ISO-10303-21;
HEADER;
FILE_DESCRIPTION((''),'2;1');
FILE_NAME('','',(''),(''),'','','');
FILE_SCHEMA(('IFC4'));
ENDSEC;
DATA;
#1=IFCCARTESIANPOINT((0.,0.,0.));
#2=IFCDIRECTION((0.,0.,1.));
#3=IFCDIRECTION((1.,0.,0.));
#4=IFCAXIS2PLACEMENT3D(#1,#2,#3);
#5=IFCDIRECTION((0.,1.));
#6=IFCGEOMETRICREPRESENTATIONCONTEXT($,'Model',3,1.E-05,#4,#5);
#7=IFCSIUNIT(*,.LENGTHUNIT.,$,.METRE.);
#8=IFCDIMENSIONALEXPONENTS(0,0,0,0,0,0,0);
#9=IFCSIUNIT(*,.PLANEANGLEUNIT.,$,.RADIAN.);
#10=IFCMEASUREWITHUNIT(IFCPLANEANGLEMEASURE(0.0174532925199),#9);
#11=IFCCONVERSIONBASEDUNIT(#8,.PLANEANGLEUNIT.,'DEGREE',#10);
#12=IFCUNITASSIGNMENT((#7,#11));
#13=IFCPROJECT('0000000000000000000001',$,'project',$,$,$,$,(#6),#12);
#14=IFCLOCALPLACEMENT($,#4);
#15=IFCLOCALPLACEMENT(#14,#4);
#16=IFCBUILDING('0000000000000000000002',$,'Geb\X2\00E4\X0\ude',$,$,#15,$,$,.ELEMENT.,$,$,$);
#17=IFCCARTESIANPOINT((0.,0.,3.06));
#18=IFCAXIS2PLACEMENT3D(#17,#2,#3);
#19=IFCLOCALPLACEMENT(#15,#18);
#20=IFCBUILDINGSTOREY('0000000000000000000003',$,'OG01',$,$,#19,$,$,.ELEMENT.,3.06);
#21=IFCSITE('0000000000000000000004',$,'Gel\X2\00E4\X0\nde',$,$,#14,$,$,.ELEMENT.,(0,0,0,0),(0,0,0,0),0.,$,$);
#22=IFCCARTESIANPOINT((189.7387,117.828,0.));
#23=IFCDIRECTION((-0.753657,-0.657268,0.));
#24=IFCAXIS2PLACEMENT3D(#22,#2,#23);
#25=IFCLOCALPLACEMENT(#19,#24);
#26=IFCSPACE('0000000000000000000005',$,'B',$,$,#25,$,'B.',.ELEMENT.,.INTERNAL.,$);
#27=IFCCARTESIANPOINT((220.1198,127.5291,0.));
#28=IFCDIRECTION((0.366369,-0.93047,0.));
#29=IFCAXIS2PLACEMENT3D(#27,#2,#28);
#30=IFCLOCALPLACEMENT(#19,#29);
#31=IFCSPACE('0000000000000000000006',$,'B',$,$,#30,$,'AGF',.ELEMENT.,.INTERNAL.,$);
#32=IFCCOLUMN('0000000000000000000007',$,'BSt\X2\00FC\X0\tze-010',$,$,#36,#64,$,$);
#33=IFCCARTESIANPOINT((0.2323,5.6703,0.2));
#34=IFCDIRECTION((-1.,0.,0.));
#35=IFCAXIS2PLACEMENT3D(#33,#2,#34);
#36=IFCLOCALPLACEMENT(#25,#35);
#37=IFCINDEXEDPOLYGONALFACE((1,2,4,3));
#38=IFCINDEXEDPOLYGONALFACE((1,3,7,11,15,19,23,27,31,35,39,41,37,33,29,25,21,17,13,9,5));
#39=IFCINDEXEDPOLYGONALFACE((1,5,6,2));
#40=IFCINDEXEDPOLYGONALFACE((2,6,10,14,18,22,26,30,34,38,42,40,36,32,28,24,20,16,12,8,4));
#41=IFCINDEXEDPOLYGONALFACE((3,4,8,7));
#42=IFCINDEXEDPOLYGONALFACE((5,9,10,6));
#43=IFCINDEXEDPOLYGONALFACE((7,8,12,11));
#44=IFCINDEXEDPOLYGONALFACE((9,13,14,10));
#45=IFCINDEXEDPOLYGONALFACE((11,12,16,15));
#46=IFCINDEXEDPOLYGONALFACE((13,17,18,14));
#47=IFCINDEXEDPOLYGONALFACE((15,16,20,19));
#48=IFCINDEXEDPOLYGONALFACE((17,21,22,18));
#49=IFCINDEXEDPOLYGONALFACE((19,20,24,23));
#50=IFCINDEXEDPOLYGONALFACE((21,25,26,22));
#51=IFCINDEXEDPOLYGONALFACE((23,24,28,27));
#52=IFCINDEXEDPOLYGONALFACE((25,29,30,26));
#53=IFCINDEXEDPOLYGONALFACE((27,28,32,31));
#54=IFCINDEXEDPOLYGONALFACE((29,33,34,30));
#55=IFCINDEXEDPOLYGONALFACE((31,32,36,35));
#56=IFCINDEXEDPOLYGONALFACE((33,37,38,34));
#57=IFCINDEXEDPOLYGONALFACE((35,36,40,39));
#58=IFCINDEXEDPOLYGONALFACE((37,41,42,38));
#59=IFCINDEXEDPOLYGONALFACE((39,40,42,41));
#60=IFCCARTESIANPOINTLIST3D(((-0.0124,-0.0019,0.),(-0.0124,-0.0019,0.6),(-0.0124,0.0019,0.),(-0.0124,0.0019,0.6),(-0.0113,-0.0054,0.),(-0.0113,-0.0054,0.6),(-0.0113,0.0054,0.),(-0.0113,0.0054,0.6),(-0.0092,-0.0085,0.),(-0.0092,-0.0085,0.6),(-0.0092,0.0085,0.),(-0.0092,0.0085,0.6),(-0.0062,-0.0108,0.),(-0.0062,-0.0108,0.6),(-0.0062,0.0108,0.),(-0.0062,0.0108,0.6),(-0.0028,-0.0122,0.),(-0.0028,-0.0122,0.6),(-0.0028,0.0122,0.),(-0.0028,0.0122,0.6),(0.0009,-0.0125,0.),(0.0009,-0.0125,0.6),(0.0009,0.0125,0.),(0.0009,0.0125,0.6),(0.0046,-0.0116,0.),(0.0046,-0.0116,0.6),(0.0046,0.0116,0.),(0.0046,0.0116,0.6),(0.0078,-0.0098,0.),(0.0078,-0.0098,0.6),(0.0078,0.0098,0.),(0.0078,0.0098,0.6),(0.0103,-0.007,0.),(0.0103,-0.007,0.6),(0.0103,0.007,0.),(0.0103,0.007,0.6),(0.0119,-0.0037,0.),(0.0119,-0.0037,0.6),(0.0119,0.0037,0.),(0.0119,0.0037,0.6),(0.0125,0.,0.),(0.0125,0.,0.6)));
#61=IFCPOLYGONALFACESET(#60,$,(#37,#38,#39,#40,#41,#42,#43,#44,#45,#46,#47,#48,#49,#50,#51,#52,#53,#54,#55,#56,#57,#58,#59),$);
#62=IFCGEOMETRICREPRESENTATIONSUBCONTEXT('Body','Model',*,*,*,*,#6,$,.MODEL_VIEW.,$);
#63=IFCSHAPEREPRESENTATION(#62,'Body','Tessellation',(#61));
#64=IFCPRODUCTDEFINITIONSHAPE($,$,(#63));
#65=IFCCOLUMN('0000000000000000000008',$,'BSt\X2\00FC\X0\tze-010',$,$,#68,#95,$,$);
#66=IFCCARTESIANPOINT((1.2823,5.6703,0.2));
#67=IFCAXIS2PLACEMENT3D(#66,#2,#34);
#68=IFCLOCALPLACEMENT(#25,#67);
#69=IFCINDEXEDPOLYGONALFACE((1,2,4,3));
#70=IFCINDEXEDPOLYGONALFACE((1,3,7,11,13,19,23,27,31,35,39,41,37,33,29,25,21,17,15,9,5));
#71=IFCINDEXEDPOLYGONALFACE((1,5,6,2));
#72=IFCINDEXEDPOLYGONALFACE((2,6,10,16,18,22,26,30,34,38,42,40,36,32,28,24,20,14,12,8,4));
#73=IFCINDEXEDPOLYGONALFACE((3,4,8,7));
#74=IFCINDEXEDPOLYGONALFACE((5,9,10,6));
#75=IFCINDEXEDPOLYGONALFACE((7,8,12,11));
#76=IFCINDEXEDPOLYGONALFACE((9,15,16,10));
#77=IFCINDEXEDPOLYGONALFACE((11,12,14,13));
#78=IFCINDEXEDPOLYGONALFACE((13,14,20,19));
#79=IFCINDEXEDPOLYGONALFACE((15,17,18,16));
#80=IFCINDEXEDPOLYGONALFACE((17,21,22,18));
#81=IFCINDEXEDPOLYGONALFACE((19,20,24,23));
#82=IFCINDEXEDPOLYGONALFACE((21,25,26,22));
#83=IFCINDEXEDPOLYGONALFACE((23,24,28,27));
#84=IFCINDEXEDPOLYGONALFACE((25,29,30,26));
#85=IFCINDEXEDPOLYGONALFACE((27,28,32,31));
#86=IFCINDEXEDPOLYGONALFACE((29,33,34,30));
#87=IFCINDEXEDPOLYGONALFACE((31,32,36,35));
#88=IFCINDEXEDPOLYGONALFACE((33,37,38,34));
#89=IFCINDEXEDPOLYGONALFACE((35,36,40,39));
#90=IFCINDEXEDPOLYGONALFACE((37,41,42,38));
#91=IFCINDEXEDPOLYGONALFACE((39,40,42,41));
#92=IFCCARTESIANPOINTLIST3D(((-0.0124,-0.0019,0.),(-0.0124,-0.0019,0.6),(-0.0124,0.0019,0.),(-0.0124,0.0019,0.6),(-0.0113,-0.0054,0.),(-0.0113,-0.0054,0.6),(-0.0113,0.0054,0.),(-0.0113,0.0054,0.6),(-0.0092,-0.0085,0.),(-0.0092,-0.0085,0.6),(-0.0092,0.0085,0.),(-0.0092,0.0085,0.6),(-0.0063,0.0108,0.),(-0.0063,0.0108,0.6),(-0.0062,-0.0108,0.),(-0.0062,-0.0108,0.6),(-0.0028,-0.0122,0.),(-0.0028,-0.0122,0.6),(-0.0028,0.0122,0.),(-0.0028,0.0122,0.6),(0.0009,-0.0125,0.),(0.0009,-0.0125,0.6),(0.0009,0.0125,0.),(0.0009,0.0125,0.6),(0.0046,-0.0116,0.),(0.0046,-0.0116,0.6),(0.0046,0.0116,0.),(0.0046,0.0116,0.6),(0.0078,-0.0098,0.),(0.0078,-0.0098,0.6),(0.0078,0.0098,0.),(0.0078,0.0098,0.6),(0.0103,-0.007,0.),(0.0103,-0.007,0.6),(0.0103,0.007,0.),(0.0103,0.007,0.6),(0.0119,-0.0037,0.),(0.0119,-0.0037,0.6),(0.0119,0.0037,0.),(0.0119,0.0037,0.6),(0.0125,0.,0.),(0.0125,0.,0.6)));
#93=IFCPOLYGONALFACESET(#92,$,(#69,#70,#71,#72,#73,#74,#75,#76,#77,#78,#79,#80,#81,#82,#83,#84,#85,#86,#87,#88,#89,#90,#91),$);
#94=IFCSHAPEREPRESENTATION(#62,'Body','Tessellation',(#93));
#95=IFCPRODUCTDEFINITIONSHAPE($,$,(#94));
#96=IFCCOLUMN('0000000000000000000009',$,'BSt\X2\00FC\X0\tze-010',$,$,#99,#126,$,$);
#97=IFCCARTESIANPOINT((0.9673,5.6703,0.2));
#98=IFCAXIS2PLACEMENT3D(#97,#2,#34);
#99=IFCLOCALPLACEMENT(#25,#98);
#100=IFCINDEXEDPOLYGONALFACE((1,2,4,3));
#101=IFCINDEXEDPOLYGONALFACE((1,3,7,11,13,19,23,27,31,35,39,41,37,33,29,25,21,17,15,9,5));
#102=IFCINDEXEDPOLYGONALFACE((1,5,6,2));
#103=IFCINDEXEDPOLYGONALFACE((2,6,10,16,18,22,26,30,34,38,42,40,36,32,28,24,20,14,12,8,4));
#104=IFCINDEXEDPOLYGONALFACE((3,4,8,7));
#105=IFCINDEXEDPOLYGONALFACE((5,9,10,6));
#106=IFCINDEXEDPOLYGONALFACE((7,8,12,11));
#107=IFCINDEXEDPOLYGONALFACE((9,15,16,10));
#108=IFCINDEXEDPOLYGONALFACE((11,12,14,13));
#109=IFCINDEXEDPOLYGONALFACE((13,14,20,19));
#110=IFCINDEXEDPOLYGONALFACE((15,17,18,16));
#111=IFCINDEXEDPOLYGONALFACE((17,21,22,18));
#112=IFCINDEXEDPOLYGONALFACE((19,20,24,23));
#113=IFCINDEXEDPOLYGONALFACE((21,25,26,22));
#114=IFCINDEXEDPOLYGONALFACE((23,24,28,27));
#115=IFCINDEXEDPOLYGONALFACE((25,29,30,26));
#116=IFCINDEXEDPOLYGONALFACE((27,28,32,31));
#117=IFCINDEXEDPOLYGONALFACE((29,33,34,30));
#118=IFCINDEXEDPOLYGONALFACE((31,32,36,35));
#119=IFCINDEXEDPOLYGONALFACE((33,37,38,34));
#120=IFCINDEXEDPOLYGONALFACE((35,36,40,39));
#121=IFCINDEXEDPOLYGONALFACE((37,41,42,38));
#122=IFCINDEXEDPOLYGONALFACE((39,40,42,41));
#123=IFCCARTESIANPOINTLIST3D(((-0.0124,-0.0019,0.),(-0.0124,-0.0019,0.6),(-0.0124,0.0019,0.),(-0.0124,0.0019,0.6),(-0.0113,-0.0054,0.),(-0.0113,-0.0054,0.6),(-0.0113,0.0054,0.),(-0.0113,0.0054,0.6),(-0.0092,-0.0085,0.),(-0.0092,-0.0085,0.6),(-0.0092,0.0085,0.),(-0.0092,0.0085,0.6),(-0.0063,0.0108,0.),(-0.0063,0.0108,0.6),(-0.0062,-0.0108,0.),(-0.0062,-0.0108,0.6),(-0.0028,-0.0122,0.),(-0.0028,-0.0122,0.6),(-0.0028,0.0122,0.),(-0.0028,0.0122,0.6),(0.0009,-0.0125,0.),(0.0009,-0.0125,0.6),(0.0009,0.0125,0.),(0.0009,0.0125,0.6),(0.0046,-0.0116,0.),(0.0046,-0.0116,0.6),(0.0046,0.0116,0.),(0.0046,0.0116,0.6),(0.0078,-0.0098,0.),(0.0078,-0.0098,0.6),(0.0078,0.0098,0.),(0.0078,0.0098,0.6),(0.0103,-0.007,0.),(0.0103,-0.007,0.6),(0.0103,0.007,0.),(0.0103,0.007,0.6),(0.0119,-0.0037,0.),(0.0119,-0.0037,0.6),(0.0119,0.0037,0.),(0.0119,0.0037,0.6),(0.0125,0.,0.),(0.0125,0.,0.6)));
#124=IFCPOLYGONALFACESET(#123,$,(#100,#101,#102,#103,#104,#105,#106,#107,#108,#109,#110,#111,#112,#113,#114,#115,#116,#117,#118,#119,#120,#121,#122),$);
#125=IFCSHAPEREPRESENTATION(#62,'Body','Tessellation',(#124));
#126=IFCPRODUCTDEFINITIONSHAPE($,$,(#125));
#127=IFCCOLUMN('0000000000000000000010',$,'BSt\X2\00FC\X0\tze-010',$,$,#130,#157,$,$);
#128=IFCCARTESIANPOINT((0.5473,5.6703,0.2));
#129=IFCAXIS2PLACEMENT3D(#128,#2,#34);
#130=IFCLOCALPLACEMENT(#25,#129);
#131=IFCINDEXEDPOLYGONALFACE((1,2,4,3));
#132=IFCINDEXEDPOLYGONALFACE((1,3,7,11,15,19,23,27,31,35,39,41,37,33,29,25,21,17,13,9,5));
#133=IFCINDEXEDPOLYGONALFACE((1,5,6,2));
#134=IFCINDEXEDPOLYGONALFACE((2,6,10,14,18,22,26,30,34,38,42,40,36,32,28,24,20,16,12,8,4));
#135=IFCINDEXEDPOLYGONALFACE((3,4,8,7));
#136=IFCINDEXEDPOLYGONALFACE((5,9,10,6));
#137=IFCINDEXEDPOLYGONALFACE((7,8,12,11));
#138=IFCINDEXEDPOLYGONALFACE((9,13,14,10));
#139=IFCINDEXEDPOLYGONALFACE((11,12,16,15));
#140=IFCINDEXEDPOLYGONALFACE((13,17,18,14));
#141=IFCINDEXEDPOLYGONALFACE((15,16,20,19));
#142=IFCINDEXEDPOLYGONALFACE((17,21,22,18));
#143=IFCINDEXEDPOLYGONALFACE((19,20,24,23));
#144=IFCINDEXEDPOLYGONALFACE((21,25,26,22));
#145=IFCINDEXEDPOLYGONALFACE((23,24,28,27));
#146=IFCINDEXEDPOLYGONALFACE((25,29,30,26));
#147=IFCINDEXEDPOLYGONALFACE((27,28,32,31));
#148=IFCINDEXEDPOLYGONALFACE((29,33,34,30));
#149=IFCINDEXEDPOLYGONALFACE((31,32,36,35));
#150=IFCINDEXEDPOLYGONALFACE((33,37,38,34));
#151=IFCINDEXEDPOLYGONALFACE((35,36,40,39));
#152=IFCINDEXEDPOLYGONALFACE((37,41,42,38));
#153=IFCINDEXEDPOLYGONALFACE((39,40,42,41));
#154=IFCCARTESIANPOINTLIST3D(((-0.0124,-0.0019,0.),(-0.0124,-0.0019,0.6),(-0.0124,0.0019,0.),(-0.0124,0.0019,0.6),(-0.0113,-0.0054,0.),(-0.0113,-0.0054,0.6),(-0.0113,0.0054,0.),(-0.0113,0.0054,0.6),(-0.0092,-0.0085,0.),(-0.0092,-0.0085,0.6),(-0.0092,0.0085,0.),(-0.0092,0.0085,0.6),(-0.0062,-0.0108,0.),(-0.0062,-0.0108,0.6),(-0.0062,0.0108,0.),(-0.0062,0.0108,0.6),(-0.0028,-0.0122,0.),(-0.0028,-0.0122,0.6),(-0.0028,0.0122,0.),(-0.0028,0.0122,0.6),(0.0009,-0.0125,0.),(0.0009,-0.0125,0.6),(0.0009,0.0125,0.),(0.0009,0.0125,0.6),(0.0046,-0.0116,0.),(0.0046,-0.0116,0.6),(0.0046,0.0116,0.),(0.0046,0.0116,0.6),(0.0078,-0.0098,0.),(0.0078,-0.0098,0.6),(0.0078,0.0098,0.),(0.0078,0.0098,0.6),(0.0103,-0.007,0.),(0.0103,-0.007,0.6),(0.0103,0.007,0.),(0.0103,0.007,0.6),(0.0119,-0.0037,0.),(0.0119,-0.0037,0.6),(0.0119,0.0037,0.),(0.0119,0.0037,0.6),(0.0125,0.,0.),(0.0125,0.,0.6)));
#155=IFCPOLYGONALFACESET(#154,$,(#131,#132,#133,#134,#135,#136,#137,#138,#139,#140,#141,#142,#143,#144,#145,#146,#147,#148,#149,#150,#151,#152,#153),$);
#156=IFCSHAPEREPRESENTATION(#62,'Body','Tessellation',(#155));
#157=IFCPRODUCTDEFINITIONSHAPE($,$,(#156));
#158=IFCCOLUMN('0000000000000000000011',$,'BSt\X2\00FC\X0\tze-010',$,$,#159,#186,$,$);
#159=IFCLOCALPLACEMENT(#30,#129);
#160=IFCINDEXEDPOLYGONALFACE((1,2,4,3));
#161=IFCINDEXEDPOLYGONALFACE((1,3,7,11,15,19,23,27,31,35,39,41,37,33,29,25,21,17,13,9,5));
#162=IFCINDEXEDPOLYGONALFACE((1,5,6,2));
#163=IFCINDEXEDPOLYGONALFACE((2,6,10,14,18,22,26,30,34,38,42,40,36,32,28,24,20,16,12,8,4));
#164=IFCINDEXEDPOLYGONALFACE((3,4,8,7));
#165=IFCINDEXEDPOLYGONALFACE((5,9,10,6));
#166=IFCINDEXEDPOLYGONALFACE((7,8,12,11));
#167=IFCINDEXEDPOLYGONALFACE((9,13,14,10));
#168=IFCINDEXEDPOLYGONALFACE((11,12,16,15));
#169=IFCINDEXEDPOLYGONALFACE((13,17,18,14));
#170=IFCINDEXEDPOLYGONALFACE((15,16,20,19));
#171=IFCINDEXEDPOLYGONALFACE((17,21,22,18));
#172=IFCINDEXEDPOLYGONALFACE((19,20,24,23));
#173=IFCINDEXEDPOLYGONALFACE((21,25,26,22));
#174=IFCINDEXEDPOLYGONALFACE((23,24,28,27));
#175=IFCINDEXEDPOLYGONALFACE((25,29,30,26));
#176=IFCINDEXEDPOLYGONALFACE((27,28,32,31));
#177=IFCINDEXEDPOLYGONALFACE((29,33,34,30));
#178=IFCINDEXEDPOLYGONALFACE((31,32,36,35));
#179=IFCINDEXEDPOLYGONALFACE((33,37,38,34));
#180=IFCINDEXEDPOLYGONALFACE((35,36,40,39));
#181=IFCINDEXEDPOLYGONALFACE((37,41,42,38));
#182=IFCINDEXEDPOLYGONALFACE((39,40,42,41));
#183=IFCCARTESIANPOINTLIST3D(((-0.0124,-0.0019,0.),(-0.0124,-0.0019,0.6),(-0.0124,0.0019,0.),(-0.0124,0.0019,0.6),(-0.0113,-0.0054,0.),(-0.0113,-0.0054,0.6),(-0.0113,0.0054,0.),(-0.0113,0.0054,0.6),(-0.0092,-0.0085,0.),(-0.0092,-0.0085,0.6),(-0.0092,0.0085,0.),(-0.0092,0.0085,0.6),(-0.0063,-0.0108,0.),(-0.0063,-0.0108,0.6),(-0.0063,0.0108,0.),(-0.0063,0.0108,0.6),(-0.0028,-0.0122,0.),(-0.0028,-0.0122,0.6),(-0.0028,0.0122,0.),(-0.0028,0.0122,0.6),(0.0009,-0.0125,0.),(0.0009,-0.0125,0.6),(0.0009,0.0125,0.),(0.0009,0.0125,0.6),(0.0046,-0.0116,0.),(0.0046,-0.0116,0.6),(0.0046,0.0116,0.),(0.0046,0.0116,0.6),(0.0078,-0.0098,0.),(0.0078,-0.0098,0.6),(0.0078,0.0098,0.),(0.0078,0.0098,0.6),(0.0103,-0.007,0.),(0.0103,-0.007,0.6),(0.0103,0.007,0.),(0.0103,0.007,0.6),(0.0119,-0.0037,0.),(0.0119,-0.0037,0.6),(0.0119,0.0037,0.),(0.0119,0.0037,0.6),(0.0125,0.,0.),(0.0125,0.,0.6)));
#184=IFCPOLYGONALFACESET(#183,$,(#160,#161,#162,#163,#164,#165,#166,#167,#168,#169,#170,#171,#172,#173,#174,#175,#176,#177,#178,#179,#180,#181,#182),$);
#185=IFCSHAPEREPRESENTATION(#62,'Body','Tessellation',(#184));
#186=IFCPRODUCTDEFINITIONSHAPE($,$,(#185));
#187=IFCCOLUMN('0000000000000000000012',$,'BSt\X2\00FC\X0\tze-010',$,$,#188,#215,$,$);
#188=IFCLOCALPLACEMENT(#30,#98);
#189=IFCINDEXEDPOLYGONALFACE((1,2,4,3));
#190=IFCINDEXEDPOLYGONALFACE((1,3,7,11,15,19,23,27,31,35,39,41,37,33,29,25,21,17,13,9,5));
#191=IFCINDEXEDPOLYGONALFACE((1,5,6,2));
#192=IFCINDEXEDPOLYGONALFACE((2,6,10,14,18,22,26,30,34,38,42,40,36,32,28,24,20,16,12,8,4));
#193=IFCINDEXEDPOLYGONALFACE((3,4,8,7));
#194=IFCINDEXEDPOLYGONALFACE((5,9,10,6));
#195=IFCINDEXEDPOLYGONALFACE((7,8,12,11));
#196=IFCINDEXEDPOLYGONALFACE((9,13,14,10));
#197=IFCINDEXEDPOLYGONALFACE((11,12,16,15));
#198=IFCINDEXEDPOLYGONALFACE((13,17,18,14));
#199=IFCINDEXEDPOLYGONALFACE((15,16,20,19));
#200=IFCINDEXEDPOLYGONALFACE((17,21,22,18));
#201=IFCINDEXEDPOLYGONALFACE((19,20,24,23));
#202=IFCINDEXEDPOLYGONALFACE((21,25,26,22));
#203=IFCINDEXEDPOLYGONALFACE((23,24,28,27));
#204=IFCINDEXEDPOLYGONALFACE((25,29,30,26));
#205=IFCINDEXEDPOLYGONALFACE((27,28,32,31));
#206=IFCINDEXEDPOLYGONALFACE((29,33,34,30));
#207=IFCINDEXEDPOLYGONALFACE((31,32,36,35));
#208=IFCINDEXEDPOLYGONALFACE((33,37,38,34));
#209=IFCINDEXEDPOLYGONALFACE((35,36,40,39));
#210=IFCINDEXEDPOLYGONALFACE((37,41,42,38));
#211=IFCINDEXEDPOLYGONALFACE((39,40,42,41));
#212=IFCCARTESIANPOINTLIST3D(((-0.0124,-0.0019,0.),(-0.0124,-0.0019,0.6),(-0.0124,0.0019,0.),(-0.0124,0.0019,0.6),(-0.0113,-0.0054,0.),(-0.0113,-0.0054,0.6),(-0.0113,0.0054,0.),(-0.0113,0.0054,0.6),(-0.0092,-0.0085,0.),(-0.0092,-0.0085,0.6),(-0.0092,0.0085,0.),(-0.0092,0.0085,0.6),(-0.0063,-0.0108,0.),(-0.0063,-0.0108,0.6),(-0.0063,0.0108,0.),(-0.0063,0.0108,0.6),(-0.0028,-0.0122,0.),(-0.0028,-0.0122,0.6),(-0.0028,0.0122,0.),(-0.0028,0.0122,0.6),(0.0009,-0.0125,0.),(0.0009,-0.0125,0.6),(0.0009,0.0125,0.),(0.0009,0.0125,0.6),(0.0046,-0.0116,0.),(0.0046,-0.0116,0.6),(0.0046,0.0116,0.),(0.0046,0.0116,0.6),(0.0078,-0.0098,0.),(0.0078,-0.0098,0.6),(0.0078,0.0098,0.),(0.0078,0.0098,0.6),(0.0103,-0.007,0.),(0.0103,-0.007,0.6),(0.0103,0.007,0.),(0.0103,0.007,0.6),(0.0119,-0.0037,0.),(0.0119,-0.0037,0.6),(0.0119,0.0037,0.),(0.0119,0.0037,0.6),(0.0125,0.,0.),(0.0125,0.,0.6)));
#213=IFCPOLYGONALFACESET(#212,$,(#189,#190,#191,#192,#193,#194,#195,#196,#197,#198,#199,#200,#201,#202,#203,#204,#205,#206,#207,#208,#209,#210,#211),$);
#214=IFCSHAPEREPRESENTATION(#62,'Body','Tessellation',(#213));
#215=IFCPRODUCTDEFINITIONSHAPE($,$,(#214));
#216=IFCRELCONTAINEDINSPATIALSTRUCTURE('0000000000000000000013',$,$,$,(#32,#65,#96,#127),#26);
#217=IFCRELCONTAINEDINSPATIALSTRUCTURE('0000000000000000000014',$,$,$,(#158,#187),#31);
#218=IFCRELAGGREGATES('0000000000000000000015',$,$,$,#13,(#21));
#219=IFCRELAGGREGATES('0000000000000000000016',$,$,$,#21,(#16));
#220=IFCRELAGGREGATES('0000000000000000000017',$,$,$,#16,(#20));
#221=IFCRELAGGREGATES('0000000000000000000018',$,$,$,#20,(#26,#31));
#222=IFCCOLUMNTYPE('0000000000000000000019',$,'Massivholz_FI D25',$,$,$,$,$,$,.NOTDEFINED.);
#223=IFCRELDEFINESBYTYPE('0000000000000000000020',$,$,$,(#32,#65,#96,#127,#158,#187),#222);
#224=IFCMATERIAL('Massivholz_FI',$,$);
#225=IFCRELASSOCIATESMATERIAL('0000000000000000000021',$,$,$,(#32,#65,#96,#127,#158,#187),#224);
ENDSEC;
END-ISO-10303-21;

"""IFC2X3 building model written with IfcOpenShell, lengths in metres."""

from ifc_helpers import new_model, entity, si_unit, converted_unit, direction, frame, origin_with_axes, origin_2d_with_axis, place, context, subcontext, project, spatial, circle, extrude, material, type_object, element, save


model = new_model("IFC2X3")

# Units and contexts
model_context = context("Model", 3, precision=1e-05, world=origin_with_axes(), true_north=direction((0.0, 1.0)))
body_context = subcontext(model_context, "Body", "Model", "MODEL_VIEW")
ifc_project = project(units=[si_unit("LENGTHUNIT", "METRE"), converted_unit("PLANEANGLEUNIT", "DEGREE", entity("IfcPlaneAngleMeasure", 0.0174532925199), si_unit("PLANEANGLEUNIT", "RADIAN"), dimensions=[0, 0, 0, 0, 0, 0, 0])], contexts=[model_context])

# Site, building, storey, space
site_placement = place(None, origin_with_axes())
site = spatial("IfcSite", under=ifc_project, at=site_placement, Name="Gelände", CompositionType="ELEMENT", RefLatitude=(0, 0, 0, 0), RefLongitude=(0, 0, 0, 0), RefElevation=0.0)
building_placement = place(site_placement, origin_with_axes())
building = spatial("IfcBuilding", under=site, at=building_placement, Name="Gebäude", CompositionType="ELEMENT")
storey_placement = place(building_placement, frame((0.0, 0.0, 3.06), z_axis=(0.0, 0.0, 1.0), x_axis=(1.0, 0.0, 0.0)))
storey = spatial("IfcBuildingStorey", under=building, at=storey_placement, Name="OG01", CompositionType="ELEMENT", Elevation=3.06)
space_1_placement = place(storey_placement, frame((189.7387, 117.828, 0.0), z_axis=(0.0, 0.0, 1.0), x_axis=(-0.753657, -0.657268, 0.0)))
space_1 = spatial("IfcSpace", under=storey, at=space_1_placement, Name="B", LongName="B.", CompositionType="ELEMENT", InteriorOrExteriorSpace="INTERNAL")

# Columns
ifc_material_1 = material(Name="Massivholz_FI")
column_type = type_object("IfcColumnType", Name="Massivholz_FI D25", PredefinedType="NOTDEFINED")
for number, where, z_axis, x_axis, name in (
    (1, (0.2323, 5.6703, 0.2), (0.0, 0.0, 1.0), (-1.0, 0.0, 0.0), "BStütze-010"),
    (2, (1.2823, 5.6703, 0.2), (0.0, 0.0, 1.0), (-1.0, 0.0, 0.0), "BStütze-010"),
    (3, (0.9673, 5.6703, 0.2), (0.0, 0.0, 1.0), (-1.0, 0.0, 0.0), "BStütze-010"),
    (4, (0.5473, 5.6703, 0.2), (0.0, 0.0, 1.0), (-1.0, 0.0, 0.0), "BStütze-010"),
):
    element("IfcColumn", number, at=place(space_1_placement, frame(where, z_axis=z_axis, x_axis=x_axis)), inside=space_1, type_object=column_type, material=ifc_material_1, Name=name, context=body_context, shape_type="SweptSolid", body=[
        extrude(circle(Radius=0.0125, at=origin_2d_with_axis()), origin_with_axes(), (0.0, 0.0, 1.0), 0.6),
    ])

# Shared definitions
space_2_placement = place(storey_placement, frame((220.1198, 127.5291, 0.0), z_axis=(0.0, 0.0, 1.0), x_axis=(0.366369, -0.93047, 0.0)))
space_2 = spatial("IfcSpace", under=storey, at=space_2_placement, Name="B", LongName="AGF", CompositionType="ELEMENT", InteriorOrExteriorSpace="INTERNAL")

# Columns
for number, where, z_axis, x_axis, name in (
    (5, (0.5473, 5.6703, 0.2), (0.0, 0.0, 1.0), (-1.0, 0.0, 0.0), "BStütze-010"),
    (6, (0.9673, 5.6703, 0.2), (0.0, 0.0, 1.0), (-1.0, 0.0, 0.0), "BStütze-010"),
):
    element("IfcColumn", number, at=place(space_2_placement, frame(where, z_axis=z_axis, x_axis=x_axis)), inside=space_2, type_object=column_type, material=ifc_material_1, Name=name, context=body_context, shape_type="SweptSolid", body=[
        extrude(circle(Radius=0.0125, at=origin_2d_with_axis()), origin_with_axes(), (0.0, 0.0, 1.0), 0.6),
    ])

save(model, "model.ifc")
